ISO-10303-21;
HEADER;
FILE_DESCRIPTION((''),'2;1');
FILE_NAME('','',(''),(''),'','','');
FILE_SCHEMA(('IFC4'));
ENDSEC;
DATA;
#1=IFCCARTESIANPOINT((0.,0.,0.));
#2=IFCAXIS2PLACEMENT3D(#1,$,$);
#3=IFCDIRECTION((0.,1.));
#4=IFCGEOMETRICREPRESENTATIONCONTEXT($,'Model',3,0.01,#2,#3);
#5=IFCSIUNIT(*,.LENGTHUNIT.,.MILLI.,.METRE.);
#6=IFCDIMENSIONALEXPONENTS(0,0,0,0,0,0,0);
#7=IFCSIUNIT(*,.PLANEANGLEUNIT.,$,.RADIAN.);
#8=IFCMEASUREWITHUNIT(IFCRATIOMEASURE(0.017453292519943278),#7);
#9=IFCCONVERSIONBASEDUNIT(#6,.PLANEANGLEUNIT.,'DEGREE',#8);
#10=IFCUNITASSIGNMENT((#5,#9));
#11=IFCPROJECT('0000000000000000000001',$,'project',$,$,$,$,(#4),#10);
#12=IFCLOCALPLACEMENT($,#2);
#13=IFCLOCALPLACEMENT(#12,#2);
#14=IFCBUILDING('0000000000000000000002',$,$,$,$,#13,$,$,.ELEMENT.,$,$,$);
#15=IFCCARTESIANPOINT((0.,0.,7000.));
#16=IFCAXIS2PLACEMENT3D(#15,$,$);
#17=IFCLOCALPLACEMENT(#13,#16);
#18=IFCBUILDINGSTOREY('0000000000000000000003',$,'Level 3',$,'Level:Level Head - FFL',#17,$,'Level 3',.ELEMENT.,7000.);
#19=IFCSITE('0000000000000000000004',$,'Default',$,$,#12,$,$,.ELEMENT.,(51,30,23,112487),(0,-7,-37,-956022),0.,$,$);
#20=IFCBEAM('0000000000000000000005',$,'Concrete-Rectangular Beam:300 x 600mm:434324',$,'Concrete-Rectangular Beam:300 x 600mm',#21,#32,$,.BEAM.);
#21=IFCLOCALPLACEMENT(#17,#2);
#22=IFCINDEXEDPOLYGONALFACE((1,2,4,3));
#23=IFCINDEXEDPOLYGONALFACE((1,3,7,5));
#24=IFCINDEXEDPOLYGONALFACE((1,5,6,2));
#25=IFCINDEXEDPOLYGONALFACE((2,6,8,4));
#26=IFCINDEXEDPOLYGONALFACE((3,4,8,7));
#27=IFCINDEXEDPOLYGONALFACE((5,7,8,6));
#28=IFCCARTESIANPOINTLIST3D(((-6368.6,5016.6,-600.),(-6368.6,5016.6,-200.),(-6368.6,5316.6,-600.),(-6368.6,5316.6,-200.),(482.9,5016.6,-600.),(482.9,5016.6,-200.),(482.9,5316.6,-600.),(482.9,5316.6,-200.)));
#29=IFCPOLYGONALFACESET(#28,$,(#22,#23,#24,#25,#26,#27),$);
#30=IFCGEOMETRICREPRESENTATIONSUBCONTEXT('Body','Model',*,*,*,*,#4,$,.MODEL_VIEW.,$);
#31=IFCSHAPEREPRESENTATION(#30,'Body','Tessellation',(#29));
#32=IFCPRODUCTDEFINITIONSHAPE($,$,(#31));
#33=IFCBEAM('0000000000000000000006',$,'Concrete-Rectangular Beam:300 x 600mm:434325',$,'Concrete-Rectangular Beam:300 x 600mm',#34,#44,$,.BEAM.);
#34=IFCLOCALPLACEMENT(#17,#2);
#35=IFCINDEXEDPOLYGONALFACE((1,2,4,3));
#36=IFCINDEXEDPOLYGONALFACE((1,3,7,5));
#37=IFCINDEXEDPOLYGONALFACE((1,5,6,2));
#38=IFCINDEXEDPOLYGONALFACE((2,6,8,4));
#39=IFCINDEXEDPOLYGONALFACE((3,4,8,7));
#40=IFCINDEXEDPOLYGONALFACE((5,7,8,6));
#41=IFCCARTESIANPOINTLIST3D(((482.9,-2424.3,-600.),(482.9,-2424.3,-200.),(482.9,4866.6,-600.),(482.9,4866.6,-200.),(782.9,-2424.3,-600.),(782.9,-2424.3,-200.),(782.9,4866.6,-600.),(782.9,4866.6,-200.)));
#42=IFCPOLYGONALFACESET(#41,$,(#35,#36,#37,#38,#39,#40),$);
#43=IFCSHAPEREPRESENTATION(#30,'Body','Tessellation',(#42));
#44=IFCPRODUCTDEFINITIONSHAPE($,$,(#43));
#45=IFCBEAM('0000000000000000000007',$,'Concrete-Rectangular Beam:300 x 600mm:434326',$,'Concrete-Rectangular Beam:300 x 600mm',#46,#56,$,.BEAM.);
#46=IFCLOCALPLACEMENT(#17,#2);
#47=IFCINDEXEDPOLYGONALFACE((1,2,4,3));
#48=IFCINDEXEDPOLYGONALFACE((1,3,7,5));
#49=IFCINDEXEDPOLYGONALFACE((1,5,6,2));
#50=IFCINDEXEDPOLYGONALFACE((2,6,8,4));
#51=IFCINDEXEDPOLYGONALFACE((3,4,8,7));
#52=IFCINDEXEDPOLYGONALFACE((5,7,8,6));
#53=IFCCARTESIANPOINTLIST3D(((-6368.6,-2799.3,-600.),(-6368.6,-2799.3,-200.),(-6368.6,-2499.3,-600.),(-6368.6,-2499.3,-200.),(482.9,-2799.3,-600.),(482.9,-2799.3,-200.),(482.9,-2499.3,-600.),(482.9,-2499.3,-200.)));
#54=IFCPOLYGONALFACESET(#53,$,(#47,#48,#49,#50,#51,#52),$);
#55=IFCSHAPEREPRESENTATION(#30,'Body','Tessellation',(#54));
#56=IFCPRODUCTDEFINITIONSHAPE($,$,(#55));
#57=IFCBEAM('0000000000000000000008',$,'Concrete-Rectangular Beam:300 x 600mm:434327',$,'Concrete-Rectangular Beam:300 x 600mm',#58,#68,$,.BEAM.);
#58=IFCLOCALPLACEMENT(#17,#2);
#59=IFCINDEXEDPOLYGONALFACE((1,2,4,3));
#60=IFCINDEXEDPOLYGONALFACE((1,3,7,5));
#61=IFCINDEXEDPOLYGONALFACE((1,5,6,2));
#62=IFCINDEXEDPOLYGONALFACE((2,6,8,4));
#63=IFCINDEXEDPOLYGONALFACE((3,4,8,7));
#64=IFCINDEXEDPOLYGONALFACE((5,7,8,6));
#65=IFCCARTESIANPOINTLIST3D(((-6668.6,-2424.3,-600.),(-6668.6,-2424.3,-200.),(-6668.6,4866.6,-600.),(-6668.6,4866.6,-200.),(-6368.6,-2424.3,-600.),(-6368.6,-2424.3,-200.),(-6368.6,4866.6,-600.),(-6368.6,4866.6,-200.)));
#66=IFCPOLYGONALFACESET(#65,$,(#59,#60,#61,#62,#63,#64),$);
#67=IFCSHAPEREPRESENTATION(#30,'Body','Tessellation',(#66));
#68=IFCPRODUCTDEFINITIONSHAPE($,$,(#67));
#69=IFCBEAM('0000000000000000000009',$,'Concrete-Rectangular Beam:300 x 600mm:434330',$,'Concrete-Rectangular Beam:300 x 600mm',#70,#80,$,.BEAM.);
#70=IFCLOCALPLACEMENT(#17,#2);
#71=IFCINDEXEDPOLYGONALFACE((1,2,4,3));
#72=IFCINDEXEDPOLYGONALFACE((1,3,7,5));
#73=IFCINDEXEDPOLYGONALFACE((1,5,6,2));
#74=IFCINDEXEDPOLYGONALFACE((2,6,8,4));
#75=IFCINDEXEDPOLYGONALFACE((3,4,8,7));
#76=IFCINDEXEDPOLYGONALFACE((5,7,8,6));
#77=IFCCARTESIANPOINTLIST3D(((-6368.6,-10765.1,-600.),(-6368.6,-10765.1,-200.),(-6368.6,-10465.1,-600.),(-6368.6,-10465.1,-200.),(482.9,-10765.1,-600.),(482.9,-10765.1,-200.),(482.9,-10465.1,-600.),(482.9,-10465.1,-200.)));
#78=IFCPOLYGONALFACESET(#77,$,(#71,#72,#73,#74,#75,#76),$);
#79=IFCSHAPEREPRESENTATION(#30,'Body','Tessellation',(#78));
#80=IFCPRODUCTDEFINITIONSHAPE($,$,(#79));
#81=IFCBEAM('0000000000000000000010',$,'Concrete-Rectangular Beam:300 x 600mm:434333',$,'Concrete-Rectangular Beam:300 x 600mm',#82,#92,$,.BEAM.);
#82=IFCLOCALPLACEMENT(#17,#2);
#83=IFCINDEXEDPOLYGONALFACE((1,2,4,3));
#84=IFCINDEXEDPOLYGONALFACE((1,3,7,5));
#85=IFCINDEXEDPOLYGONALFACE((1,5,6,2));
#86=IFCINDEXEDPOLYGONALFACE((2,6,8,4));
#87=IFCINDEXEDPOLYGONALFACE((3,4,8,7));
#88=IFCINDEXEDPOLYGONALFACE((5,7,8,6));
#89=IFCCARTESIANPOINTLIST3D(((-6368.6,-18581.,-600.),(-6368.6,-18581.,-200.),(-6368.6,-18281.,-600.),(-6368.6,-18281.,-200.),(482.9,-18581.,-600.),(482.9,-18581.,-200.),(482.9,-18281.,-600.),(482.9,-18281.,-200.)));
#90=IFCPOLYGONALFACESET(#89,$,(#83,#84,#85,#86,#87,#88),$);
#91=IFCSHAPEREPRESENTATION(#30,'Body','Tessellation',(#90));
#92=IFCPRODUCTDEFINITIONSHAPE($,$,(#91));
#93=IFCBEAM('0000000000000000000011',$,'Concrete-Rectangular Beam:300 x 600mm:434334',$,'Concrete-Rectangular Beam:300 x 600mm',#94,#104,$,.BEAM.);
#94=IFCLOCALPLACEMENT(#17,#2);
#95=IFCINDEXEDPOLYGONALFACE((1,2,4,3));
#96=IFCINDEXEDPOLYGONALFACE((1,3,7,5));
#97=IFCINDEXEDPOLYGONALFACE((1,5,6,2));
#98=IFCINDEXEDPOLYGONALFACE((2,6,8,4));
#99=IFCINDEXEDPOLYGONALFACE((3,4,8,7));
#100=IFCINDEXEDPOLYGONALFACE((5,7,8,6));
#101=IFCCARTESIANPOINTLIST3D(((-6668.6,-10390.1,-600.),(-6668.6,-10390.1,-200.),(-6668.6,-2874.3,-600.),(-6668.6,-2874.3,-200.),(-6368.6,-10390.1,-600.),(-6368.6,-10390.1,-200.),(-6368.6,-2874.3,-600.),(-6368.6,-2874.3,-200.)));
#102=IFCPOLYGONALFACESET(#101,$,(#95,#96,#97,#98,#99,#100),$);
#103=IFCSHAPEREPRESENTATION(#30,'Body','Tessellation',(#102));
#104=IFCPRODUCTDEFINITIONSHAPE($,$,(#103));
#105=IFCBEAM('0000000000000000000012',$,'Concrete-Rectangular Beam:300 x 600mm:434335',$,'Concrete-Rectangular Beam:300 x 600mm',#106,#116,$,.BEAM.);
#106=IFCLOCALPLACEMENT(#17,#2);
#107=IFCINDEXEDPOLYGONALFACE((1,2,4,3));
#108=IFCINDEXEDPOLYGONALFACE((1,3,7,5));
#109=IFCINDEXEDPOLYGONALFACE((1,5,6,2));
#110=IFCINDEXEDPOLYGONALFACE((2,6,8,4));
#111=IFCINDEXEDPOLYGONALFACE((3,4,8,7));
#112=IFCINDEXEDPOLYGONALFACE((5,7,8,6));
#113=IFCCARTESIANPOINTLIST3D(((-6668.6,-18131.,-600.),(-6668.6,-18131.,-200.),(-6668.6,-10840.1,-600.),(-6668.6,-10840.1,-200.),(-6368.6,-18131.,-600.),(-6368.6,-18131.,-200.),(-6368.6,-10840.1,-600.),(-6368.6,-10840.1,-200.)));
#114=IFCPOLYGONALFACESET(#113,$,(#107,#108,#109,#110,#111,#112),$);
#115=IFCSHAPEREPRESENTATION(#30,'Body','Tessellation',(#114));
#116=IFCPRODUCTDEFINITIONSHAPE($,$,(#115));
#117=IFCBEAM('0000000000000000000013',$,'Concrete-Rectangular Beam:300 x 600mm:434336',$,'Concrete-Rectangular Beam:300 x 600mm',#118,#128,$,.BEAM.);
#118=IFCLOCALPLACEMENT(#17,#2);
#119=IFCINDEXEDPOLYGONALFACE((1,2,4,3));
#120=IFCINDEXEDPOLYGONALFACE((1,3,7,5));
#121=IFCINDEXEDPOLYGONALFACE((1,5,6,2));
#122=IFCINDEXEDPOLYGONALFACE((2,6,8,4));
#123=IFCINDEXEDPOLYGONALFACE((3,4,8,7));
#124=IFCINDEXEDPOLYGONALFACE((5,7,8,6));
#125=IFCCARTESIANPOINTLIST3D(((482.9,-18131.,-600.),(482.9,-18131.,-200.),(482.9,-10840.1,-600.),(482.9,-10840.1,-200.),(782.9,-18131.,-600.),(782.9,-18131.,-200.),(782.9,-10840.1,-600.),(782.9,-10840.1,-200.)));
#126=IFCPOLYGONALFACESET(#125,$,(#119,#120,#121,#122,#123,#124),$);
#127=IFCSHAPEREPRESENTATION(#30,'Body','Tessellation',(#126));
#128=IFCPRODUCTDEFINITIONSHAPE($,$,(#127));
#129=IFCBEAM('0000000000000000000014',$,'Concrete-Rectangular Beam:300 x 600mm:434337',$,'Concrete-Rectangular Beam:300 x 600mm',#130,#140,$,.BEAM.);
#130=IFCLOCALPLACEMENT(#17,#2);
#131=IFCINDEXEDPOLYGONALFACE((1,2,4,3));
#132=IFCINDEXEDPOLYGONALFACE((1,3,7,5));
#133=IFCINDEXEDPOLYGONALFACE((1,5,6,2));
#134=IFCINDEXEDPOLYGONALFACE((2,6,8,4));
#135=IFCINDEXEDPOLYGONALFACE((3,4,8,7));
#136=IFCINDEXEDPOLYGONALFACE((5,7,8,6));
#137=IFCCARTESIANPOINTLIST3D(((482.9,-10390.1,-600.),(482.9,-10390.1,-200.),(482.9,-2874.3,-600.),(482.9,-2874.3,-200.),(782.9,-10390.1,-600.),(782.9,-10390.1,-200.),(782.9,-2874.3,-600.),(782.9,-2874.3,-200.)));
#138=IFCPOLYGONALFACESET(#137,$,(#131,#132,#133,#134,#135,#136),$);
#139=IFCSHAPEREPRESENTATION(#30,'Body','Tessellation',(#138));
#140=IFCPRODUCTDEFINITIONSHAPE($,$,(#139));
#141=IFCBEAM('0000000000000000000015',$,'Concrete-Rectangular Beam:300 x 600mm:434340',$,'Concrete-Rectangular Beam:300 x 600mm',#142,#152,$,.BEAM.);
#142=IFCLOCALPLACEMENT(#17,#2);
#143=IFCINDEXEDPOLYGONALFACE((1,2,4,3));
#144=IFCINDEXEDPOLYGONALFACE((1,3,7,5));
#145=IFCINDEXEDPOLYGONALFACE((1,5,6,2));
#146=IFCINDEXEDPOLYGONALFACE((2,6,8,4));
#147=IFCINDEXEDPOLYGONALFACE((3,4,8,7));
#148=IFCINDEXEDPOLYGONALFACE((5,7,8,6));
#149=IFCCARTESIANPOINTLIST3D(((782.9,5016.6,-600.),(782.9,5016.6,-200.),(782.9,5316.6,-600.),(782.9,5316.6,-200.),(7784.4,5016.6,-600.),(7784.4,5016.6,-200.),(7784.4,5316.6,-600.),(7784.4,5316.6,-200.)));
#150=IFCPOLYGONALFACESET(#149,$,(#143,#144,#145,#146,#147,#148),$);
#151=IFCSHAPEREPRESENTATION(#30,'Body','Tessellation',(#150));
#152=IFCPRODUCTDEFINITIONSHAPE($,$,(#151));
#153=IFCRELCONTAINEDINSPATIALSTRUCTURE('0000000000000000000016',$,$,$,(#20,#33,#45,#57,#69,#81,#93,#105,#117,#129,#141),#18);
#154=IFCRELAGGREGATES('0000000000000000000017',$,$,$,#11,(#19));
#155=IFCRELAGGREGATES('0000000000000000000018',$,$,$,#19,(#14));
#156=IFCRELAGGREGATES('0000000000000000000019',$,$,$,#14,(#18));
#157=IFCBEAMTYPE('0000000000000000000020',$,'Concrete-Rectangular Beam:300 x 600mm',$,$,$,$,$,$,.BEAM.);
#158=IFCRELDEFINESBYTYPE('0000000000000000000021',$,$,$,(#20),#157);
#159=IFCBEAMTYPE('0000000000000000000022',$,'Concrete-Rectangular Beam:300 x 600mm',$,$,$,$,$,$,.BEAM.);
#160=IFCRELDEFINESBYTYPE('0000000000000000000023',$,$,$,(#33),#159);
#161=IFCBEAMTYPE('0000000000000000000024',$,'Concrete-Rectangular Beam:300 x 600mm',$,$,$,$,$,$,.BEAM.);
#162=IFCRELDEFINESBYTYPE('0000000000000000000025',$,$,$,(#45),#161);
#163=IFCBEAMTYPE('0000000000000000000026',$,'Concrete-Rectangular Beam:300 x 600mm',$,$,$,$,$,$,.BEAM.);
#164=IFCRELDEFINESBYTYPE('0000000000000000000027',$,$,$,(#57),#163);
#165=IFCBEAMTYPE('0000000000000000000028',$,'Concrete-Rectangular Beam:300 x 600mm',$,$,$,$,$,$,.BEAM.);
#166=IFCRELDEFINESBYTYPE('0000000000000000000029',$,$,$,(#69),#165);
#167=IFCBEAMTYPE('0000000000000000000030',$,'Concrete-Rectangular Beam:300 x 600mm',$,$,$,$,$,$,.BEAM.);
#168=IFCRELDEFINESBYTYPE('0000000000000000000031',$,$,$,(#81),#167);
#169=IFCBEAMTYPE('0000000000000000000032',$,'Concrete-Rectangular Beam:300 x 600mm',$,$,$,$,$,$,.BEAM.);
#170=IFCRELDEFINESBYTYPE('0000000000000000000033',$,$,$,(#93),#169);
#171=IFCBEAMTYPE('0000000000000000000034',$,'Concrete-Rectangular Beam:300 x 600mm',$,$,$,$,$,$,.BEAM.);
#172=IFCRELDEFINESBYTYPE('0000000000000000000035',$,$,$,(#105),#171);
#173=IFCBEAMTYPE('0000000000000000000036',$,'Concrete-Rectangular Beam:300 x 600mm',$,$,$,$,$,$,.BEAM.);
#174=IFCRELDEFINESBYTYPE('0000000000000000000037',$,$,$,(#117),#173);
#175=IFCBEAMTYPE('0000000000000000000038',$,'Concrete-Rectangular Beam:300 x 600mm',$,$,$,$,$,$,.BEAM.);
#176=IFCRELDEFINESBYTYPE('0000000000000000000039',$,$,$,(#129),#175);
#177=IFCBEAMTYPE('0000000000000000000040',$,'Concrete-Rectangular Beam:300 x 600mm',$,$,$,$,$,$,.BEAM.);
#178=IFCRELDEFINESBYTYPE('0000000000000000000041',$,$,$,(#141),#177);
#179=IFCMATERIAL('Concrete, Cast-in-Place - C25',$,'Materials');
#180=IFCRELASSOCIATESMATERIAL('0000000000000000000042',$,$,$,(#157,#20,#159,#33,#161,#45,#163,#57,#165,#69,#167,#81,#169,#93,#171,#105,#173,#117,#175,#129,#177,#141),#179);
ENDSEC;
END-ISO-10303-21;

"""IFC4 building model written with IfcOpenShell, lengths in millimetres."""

from ifc_helpers import new_model, entity, si_unit, converted_unit, direction, frame, origin, place, context, subcontext, project, spatial, indexed_curve, outline, extrude, source, transform, mapped, material, type_object, type_shapes, element, save


model = new_model("IFC4")

# Units and contexts
model_context = context("Model", 3, precision=0.01, world=origin(), true_north=direction((0.0, 1.0)))
body_context = subcontext(model_context, "Body", "Model", "MODEL_VIEW")
ifc_project = project(units=[si_unit("LENGTHUNIT", "METRE", prefix="MILLI"), converted_unit("PLANEANGLEUNIT", "DEGREE", entity("IfcRatioMeasure", 0.017453292519943278), si_unit("PLANEANGLEUNIT", "RADIAN"), dimensions=[0, 0, 0, 0, 0, 0, 0])], contexts=[model_context])

# Site, building, storey
site_placement = place(None, origin())
site = spatial("IfcSite", under=ifc_project, at=site_placement, Name="Default", CompositionType="ELEMENT", RefLatitude=(51, 30, 23, 112487), RefLongitude=(0, -7, -37, -956022), RefElevation=0.0)
building_placement = place(site_placement, origin())
building = spatial("IfcBuilding", under=site, at=building_placement, CompositionType="ELEMENT")
storey_placement = place(building_placement, frame((0.0, 0.0, 7000.0)))
storey = spatial("IfcBuildingStorey", under=building, at=storey_placement, Name="Level 3", ObjectType="Level:Level Head - FFL", LongName="Level 3", CompositionType="ELEMENT", Elevation=7000.0)

# Beams
ifc_material = material(Name="Concrete, Cast-in-Place - C25", Category="Materials")
beam_type_1 = type_object("IfcBeamType", Name="Concrete-Rectangular Beam:300 x 600mm", PredefinedType="BEAM", material=ifc_material)
shared_shape_1 = source(origin(), body_context, "Body", "SweptSolid", [
    extrude(outline(indexed_curve([(-200.0, -150.0), (200.0, -150.0), (200.0, 150.0), (-200.0, 150.0), (-200.0, -150.0)], self_intersect=False)), frame((-6368.6, 5166.6, 6600.0), z_axis=(1.0, 0.0, 0.0), x_axis=(0.0, 0.0, -1.0)), (0.0, 0.0, 1.0), 6851.5),
])
type_shapes(beam_type_1, [shared_shape_1])
beam_1_placement = place(storey_placement, frame((0.0, 0.0, -7000.0)))
element("IfcBeam", 1, at=beam_1_placement, inside=storey, type_object=beam_type_1, material=ifc_material, Name="Concrete-Rectangular Beam:300 x 600mm:434324", ObjectType="Concrete-Rectangular Beam:300 x 600mm", PredefinedType="BEAM", context=body_context, shape_type="MappedRepresentation", body=[
    mapped(shared_shape_1, transform((0.0, 0.0, 0.0), scale=1.0)),
])
beam_type_2 = type_object("IfcBeamType", Name="Concrete-Rectangular Beam:300 x 600mm", PredefinedType="BEAM", material=ifc_material)
shared_shape_2 = source(origin(), body_context, "Body", "SweptSolid", [
    extrude(outline(indexed_curve([(-150.0, -200.0), (150.0, -200.0), (150.0, 200.0), (-150.0, 200.0), (-150.0, -200.0)], self_intersect=False)), frame((632.9, 4866.6, 6600.0), z_axis=(0.0, -1.0, 0.0), x_axis=(-1.0, 0.0, 0.0)), (0.0, 0.0, 1.0), 7290.9),
])
type_shapes(beam_type_2, [shared_shape_2])
beam_2_placement = place(storey_placement, frame((0.0, 0.0, -7000.0)))
element("IfcBeam", 2, at=beam_2_placement, inside=storey, type_object=beam_type_2, material=ifc_material, Name="Concrete-Rectangular Beam:300 x 600mm:434325", ObjectType="Concrete-Rectangular Beam:300 x 600mm", PredefinedType="BEAM", context=body_context, shape_type="MappedRepresentation", body=[
    mapped(shared_shape_2, transform((0.0, 0.0, 0.0), scale=1.0)),
])
beam_type_3 = type_object("IfcBeamType", Name="Concrete-Rectangular Beam:300 x 600mm", PredefinedType="BEAM", material=ifc_material)
shared_shape_3 = source(origin(), body_context, "Body", "SweptSolid", [
    extrude(outline(indexed_curve([(-200.0, -150.0), (200.0, -150.0), (200.0, 150.0), (-200.0, 150.0), (-200.0, -150.0)], self_intersect=False)), frame((482.9, -2649.3, 6600.0), z_axis=(-1.0, 0.0, 0.0), x_axis=(0.0, 0.0, -1.0)), (0.0, 0.0, 1.0), 6851.5),
])
type_shapes(beam_type_3, [shared_shape_3])
beam_3_placement = place(storey_placement, frame((0.0, 0.0, -7000.0)))
element("IfcBeam", 3, at=beam_3_placement, inside=storey, type_object=beam_type_3, material=ifc_material, Name="Concrete-Rectangular Beam:300 x 600mm:434326", ObjectType="Concrete-Rectangular Beam:300 x 600mm", PredefinedType="BEAM", context=body_context, shape_type="MappedRepresentation", body=[
    mapped(shared_shape_3, transform((0.0, 0.0, 0.0), scale=1.0)),
])
beam_type_4 = type_object("IfcBeamType", Name="Concrete-Rectangular Beam:300 x 600mm", PredefinedType="BEAM", material=ifc_material)
shared_shape_4 = source(origin(), body_context, "Body", "SweptSolid", [
    extrude(outline(indexed_curve([(-150.0, -200.0), (150.0, -200.0), (150.0, 200.0), (-150.0, 200.0), (-150.0, -200.0)], self_intersect=False)), frame((-6518.6, -2424.3, 6600.0), z_axis=(0.0, 1.0, 0.0), x_axis=(-1.0, 0.0, 0.0)), (0.0, 0.0, 1.0), 7290.9),
])
type_shapes(beam_type_4, [shared_shape_4])
beam_4_placement = place(storey_placement, frame((0.0, 0.0, -7000.0)))
element("IfcBeam", 4, at=beam_4_placement, inside=storey, type_object=beam_type_4, material=ifc_material, Name="Concrete-Rectangular Beam:300 x 600mm:434327", ObjectType="Concrete-Rectangular Beam:300 x 600mm", PredefinedType="BEAM", context=body_context, shape_type="MappedRepresentation", body=[
    mapped(shared_shape_4, transform((0.0, 0.0, 0.0), scale=1.0)),
])
beam_type_5 = type_object("IfcBeamType", Name="Concrete-Rectangular Beam:300 x 600mm", PredefinedType="BEAM", material=ifc_material)
shared_shape_5 = source(origin(), body_context, "Body", "SweptSolid", [
    extrude(outline(indexed_curve([(-200.0, -150.0), (200.0, -150.0), (200.0, 150.0), (-200.0, 150.0), (-200.0, -150.0)], self_intersect=False)), frame((482.9, -10615.1, 6600.0), z_axis=(-1.0, 0.0, 0.0), x_axis=(0.0, 0.0, -1.0)), (0.0, 0.0, 1.0), 6851.5),
])
type_shapes(beam_type_5, [shared_shape_5])
beam_5_placement = place(storey_placement, frame((0.0, 0.0, -7000.0)))
element("IfcBeam", 5, at=beam_5_placement, inside=storey, type_object=beam_type_5, material=ifc_material, Name="Concrete-Rectangular Beam:300 x 600mm:434330", ObjectType="Concrete-Rectangular Beam:300 x 600mm", PredefinedType="BEAM", context=body_context, shape_type="MappedRepresentation", body=[
    mapped(shared_shape_5, transform((0.0, 0.0, 0.0), scale=1.0)),
])
beam_type_6 = type_object("IfcBeamType", Name="Concrete-Rectangular Beam:300 x 600mm", PredefinedType="BEAM", material=ifc_material)
shared_shape_6 = source(origin(), body_context, "Body", "SweptSolid", [
    extrude(outline(indexed_curve([(-200.0, -150.0), (200.0, -150.0), (200.0, 150.0), (-200.0, 150.0), (-200.0, -150.0)], self_intersect=False)), frame((482.9, -18431.0, 6600.0), z_axis=(-1.0, 0.0, 0.0), x_axis=(0.0, 0.0, -1.0)), (0.0, 0.0, 1.0), 6851.5),
])
type_shapes(beam_type_6, [shared_shape_6])
beam_6_placement = place(storey_placement, frame((0.0, 0.0, -7000.0)))
element("IfcBeam", 6, at=beam_6_placement, inside=storey, type_object=beam_type_6, material=ifc_material, Name="Concrete-Rectangular Beam:300 x 600mm:434333", ObjectType="Concrete-Rectangular Beam:300 x 600mm", PredefinedType="BEAM", context=body_context, shape_type="MappedRepresentation", body=[
    mapped(shared_shape_6, transform((0.0, 0.0, 0.0), scale=1.0)),
])
beam_type_7 = type_object("IfcBeamType", Name="Concrete-Rectangular Beam:300 x 600mm", PredefinedType="BEAM", material=ifc_material)
shared_shape_7 = source(origin(), body_context, "Body", "SweptSolid", [
    extrude(outline(indexed_curve([(-150.0, -200.0), (150.0, -200.0), (150.0, 200.0), (-150.0, 200.0), (-150.0, -200.0)], self_intersect=False)), frame((-6518.6, -2874.3, 6600.0), z_axis=(0.0, -1.0, 0.0), x_axis=(-1.0, 0.0, 0.0)), (0.0, 0.0, 1.0), 7515.9),
])
type_shapes(beam_type_7, [shared_shape_7])
beam_7_placement = place(storey_placement, frame((0.0, 0.0, -7000.0)))
element("IfcBeam", 7, at=beam_7_placement, inside=storey, type_object=beam_type_7, material=ifc_material, Name="Concrete-Rectangular Beam:300 x 600mm:434334", ObjectType="Concrete-Rectangular Beam:300 x 600mm", PredefinedType="BEAM", context=body_context, shape_type="MappedRepresentation", body=[
    mapped(shared_shape_7, transform((0.0, 0.0, 0.0), scale=1.0)),
])
beam_type_8 = type_object("IfcBeamType", Name="Concrete-Rectangular Beam:300 x 600mm", PredefinedType="BEAM", material=ifc_material)
shared_shape_8 = source(origin(), body_context, "Body", "SweptSolid", [
    extrude(outline(indexed_curve([(-150.0, -200.0), (150.0, -200.0), (150.0, 200.0), (-150.0, 200.0), (-150.0, -200.0)], self_intersect=False)), frame((-6518.6, -10840.1, 6600.0), z_axis=(0.0, -1.0, 0.0), x_axis=(-1.0, 0.0, 0.0)), (0.0, 0.0, 1.0), 7290.9),
])
type_shapes(beam_type_8, [shared_shape_8])
beam_8_placement = place(storey_placement, frame((0.0, 0.0, -7000.0)))
element("IfcBeam", 8, at=beam_8_placement, inside=storey, type_object=beam_type_8, material=ifc_material, Name="Concrete-Rectangular Beam:300 x 600mm:434335", ObjectType="Concrete-Rectangular Beam:300 x 600mm", PredefinedType="BEAM", context=body_context, shape_type="MappedRepresentation", body=[
    mapped(shared_shape_8, transform((0.0, 0.0, 0.0), scale=1.0)),
])
beam_type_9 = type_object("IfcBeamType", Name="Concrete-Rectangular Beam:300 x 600mm", PredefinedType="BEAM", material=ifc_material)
shared_shape_9 = source(origin(), body_context, "Body", "SweptSolid", [
    extrude(outline(indexed_curve([(-150.0, -200.0), (150.0, -200.0), (150.0, 200.0), (-150.0, 200.0), (-150.0, -200.0)], self_intersect=False)), frame((632.9, -18131.0, 6600.0), z_axis=(0.0, 1.0, 0.0), x_axis=(-1.0, 0.0, 0.0)), (0.0, 0.0, 1.0), 7290.9),
])
type_shapes(beam_type_9, [shared_shape_9])
beam_9_placement = place(storey_placement, frame((0.0, 0.0, -7000.0)))
element("IfcBeam", 9, at=beam_9_placement, inside=storey, type_object=beam_type_9, material=ifc_material, Name="Concrete-Rectangular Beam:300 x 600mm:434336", ObjectType="Concrete-Rectangular Beam:300 x 600mm", PredefinedType="BEAM", context=body_context, shape_type="MappedRepresentation", body=[
    mapped(shared_shape_9, transform((0.0, 0.0, 0.0), scale=1.0)),
])
beam_type_10 = type_object("IfcBeamType", Name="Concrete-Rectangular Beam:300 x 600mm", PredefinedType="BEAM", material=ifc_material)
shared_shape_10 = source(origin(), body_context, "Body", "SweptSolid", [
    extrude(outline(indexed_curve([(-150.0, -200.0), (150.0, -200.0), (150.0, 200.0), (-150.0, 200.0), (-150.0, -200.0)], self_intersect=False)), frame((632.9, -10390.1, 6600.0), z_axis=(0.0, 1.0, 0.0), x_axis=(-1.0, 0.0, 0.0)), (0.0, 0.0, 1.0), 7515.9),
])
type_shapes(beam_type_10, [shared_shape_10])
beam_10_placement = place(storey_placement, frame((0.0, 0.0, -7000.0)))
element("IfcBeam", 10, at=beam_10_placement, inside=storey, type_object=beam_type_10, material=ifc_material, Name="Concrete-Rectangular Beam:300 x 600mm:434337", ObjectType="Concrete-Rectangular Beam:300 x 600mm", PredefinedType="BEAM", context=body_context, shape_type="MappedRepresentation", body=[
    mapped(shared_shape_10, transform((0.0, 0.0, 0.0), scale=1.0)),
])
beam_type_11 = type_object("IfcBeamType", Name="Concrete-Rectangular Beam:300 x 600mm", PredefinedType="BEAM", material=ifc_material)
shared_shape_11 = source(origin(), body_context, "Body", "SweptSolid", [
    extrude(outline(indexed_curve([(-200.0, -150.0), (200.0, -150.0), (200.0, 150.0), (-200.0, 150.0), (-200.0, -150.0)], self_intersect=False)), frame((782.9, 5166.6, 6600.0), z_axis=(1.0, 0.0, 0.0), x_axis=(0.0, 0.0, -1.0)), (0.0, 0.0, 1.0), 7001.5),
])
type_shapes(beam_type_11, [shared_shape_11])
beam_11_placement = place(storey_placement, frame((0.0, 0.0, -7000.0)))
element("IfcBeam", 11, at=beam_11_placement, inside=storey, type_object=beam_type_11, material=ifc_material, Name="Concrete-Rectangular Beam:300 x 600mm:434340", ObjectType="Concrete-Rectangular Beam:300 x 600mm", PredefinedType="BEAM", context=body_context, shape_type="MappedRepresentation", body=[
    mapped(shared_shape_11, transform((0.0, 0.0, 0.0), scale=1.0)),
])

save(model, "model.ifc")
